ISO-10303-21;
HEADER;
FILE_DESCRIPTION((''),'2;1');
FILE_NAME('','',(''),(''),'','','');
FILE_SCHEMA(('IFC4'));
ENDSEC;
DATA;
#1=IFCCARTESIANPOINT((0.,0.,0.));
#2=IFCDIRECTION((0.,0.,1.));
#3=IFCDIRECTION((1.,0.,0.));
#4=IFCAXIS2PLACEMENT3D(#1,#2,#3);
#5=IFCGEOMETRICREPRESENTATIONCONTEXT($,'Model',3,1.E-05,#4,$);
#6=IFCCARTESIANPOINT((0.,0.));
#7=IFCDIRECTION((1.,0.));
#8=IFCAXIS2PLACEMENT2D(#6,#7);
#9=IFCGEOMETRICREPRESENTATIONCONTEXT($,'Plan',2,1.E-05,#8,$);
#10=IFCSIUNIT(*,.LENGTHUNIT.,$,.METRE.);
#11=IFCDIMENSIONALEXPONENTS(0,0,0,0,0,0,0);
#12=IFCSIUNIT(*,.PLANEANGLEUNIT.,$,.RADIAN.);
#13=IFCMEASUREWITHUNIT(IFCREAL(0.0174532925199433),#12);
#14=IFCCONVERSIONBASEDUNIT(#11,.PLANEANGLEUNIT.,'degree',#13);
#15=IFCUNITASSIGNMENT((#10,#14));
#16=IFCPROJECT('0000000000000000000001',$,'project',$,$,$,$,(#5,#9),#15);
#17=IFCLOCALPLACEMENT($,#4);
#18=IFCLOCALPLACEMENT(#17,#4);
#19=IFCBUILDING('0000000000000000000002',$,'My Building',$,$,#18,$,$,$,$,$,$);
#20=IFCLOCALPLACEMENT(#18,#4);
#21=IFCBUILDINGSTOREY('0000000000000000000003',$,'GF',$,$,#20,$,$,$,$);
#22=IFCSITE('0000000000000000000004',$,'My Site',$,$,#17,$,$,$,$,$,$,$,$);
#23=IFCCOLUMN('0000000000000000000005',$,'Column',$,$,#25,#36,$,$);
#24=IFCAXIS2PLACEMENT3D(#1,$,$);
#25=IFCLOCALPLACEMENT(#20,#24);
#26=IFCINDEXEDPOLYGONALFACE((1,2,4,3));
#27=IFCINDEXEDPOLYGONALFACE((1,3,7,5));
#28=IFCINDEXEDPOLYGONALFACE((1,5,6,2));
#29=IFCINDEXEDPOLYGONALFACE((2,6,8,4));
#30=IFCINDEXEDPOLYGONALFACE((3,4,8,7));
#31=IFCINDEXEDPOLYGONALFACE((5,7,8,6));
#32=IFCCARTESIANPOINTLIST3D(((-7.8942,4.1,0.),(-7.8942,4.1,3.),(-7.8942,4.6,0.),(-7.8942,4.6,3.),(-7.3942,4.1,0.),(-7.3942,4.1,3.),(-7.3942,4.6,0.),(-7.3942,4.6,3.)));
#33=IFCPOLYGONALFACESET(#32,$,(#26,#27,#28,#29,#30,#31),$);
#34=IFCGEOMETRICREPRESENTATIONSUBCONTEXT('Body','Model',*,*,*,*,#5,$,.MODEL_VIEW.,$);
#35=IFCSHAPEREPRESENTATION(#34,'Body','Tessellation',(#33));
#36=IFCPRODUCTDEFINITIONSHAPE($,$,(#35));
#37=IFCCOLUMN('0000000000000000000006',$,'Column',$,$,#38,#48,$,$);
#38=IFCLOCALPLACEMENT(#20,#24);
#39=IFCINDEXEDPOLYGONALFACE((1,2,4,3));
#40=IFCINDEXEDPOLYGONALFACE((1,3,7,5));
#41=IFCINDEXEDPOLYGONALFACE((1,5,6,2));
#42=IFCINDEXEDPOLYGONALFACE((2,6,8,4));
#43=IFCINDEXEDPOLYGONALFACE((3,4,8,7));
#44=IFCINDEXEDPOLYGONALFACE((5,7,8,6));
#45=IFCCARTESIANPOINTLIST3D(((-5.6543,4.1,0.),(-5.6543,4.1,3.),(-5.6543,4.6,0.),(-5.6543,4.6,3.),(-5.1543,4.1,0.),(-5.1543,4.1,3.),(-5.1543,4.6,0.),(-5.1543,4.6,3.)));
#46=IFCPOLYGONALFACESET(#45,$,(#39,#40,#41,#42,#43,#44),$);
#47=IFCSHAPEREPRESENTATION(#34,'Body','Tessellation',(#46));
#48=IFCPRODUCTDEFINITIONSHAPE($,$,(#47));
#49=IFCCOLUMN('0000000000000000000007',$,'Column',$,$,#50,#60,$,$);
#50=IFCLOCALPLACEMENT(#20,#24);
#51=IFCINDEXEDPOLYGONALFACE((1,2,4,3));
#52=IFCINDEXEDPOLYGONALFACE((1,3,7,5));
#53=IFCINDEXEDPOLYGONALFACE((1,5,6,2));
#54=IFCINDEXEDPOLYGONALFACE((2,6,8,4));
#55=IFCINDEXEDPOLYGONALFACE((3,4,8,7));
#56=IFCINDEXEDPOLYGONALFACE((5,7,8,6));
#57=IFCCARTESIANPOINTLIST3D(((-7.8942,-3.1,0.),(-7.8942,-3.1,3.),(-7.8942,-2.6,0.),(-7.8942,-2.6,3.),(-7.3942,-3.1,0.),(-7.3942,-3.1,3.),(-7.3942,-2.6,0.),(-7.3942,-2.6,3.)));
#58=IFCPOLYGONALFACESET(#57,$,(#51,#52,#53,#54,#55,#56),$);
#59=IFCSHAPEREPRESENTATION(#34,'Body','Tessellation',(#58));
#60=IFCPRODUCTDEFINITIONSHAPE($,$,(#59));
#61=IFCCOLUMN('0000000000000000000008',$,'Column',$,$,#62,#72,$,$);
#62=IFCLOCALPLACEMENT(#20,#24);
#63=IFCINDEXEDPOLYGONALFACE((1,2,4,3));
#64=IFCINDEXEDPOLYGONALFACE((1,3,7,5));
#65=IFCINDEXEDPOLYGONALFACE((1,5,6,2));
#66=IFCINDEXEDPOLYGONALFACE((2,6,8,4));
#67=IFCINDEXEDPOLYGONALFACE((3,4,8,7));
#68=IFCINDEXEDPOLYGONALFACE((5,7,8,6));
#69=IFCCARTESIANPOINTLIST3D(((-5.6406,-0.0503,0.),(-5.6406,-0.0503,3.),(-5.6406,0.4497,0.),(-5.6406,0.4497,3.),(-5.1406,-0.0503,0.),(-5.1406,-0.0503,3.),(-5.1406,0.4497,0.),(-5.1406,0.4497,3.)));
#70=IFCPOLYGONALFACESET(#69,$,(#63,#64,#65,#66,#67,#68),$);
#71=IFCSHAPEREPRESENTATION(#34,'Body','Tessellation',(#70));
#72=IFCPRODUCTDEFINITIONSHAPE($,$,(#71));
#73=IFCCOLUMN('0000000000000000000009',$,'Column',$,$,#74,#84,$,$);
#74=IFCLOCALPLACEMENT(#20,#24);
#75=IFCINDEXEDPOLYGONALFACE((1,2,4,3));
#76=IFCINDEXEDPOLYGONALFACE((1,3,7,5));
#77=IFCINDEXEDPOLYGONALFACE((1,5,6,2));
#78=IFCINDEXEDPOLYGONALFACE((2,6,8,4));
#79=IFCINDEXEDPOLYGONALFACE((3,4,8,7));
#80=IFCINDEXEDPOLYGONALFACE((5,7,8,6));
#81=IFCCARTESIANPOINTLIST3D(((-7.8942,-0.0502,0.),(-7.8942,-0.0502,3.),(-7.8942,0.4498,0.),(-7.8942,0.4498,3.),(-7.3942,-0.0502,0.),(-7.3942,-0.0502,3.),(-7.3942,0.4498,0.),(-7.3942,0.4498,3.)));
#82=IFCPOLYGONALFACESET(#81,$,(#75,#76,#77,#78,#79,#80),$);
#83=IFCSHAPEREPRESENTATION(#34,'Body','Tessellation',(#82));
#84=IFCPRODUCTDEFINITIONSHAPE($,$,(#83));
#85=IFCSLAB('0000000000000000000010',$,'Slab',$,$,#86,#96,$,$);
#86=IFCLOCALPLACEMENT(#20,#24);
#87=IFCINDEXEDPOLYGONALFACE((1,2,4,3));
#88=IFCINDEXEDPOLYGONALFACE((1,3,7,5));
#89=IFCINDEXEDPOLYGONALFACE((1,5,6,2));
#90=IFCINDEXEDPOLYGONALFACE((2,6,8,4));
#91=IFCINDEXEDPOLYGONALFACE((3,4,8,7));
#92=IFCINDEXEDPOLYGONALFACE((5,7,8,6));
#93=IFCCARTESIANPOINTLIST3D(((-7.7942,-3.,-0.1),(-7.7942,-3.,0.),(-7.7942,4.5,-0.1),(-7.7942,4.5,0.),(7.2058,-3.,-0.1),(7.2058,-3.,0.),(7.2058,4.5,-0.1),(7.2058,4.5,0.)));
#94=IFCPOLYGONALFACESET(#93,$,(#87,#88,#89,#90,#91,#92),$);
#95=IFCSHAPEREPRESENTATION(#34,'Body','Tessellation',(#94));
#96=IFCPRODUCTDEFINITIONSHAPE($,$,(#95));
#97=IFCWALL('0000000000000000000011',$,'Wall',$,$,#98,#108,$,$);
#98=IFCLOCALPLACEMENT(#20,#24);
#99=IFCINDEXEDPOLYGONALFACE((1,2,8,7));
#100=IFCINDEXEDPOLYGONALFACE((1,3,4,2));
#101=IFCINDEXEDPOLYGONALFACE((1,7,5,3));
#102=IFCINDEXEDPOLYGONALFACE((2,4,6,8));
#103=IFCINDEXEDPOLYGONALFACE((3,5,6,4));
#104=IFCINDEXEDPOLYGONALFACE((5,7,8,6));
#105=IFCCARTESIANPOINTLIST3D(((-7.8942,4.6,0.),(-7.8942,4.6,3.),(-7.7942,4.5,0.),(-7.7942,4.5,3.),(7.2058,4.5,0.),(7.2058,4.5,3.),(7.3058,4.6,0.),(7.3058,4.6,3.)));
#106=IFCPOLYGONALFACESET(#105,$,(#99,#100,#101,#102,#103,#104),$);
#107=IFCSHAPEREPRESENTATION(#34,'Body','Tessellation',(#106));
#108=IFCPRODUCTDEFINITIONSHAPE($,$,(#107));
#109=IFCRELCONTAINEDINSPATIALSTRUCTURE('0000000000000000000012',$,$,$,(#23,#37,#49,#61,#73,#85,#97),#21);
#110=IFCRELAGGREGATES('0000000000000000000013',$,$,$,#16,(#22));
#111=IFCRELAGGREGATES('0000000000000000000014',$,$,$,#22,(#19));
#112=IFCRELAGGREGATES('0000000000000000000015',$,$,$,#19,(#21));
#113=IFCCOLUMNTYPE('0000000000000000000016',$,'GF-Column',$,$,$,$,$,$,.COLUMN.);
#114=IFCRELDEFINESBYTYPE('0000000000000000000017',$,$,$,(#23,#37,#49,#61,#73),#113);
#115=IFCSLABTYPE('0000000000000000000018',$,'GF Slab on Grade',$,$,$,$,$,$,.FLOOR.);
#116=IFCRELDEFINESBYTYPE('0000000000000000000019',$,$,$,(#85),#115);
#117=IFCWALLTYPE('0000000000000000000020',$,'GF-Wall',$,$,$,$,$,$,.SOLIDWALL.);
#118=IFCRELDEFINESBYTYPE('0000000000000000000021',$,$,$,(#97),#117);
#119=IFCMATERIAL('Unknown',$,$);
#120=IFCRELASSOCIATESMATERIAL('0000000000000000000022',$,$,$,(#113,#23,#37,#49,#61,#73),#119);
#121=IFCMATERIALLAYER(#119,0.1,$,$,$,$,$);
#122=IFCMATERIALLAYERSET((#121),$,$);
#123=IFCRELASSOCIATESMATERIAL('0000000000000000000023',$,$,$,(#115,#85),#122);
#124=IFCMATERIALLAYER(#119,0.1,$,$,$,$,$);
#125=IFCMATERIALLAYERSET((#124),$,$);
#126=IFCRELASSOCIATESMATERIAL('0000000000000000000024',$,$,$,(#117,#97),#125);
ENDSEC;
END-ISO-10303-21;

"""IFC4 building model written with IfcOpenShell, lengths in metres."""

from ifc_helpers import new_model, entity, si_unit, converted_unit, frame, origin_with_axes, origin_2d_with_axis, place, context, subcontext, project, spatial, line, indexed_curve, rectangle, outline, extrude, material, layer, layer_set, layer_usage, material_profile, profile_set, profile_usage, type_object, element, save


model = new_model("IFC4")

# Units and contexts
model_context = context("Model", 3, precision=1e-05, world=origin_with_axes())
plan_context = context("Plan", 2, precision=1e-05, world=origin_2d_with_axis())
body_context_1 = subcontext(model_context, "Body", "Model", "MODEL_VIEW")
ifc_project = project(units=[si_unit("LENGTHUNIT", "METRE"), converted_unit("PLANEANGLEUNIT", "degree", entity("IfcReal", 0.0174532925199433), si_unit("PLANEANGLEUNIT", "RADIAN"), dimensions=[0, 0, 0, 0, 0, 0, 0])], contexts=[model_context, plan_context])

# Site, building, storey
site_placement = place(None, origin_with_axes())
site = spatial("IfcSite", under=ifc_project, at=site_placement, Name="My Site")
building_placement = place(site_placement, origin_with_axes())
building = spatial("IfcBuilding", under=site, at=building_placement, Name="My Building")
storey_placement = place(building_placement, origin_with_axes())
storey = spatial("IfcBuildingStorey", under=building, at=storey_placement, Name="GF")

# Columns
ifc_material = material(Name="Unknown")
ifc_material_profile = material_profile(ifc_material, rectangle(XDim=0.5, YDim=0.5))
ifc_profile_set = profile_set([ifc_material_profile])
ifc_profile_usage_1 = profile_usage(ifc_profile_set, cardinal=9)
column_type = type_object("IfcColumnType", Name="GF-Column", PredefinedType="COLUMN", material=ifc_profile_set)
column_1_placement = place(storey_placement, frame((-7.8942, 4.6, 0.0), z_axis=(0.0, 0.0, 1.0), x_axis=(1.0, 0.0, 0.0)))
element("IfcColumn", 1, at=column_1_placement, inside=storey, type_object=column_type, material=ifc_profile_usage_1, Name="Column", context=body_context_1, shape_type="SweptSolid", body=[
    extrude(rectangle(XDim=0.5, YDim=0.5), frame((0.25, -0.25, 0.0), z_axis=(0.0, 0.0, 1.0), x_axis=(1.0, 0.0, 0.0)), (0.0, 0.0, 1.0), 3.0),
])
ifc_profile_usage_2 = profile_usage(ifc_profile_set, cardinal=7)
column_2_placement = place(storey_placement, frame((-5.1543, 4.6, 0.0), z_axis=(0.0, 0.0, 1.0), x_axis=(1.0, 0.0, 0.0)))
element("IfcColumn", 2, at=column_2_placement, inside=storey, type_object=column_type, material=ifc_profile_usage_2, Name="Column", context=body_context_1, shape_type="SweptSolid", body=[
    extrude(rectangle(XDim=0.5, YDim=0.5), frame((-0.25, -0.25, 0.0), z_axis=(0.0, 0.0, 1.0), x_axis=(1.0, 0.0, 0.0)), (0.0, 0.0, 1.0), 3.0),
])
ifc_profile_usage_3 = profile_usage(ifc_profile_set, cardinal=3)
column_3_placement = place(storey_placement, frame((-7.8942, -3.1, 0.0), z_axis=(0.0, 0.0, 1.0), x_axis=(1.0, 0.0, 0.0)))
element("IfcColumn", 3, at=column_3_placement, inside=storey, type_object=column_type, material=ifc_profile_usage_3, Name="Column", context=body_context_1, shape_type="SweptSolid", body=[
    extrude(rectangle(XDim=0.5, YDim=0.5), frame((0.25, 0.25, 0.0), z_axis=(0.0, 0.0, 1.0), x_axis=(1.0, 0.0, 0.0)), (0.0, 0.0, 1.0), 3.0),
])
ifc_profile_usage_4 = profile_usage(ifc_profile_set, cardinal=1)
column_4_placement = place(storey_placement, frame((-5.1406, -0.0503, 0.0), z_axis=(0.0, 0.0, 1.0), x_axis=(1.0, 0.0, 0.0)))
element("IfcColumn", 4, at=column_4_placement, inside=storey, type_object=column_type, material=ifc_profile_usage_4, Name="Column", context=body_context_1, shape_type="SweptSolid", body=[
    extrude(rectangle(XDim=0.5, YDim=0.5), frame((-0.25, 0.25, 0.0), z_axis=(0.0, 0.0, 1.0), x_axis=(1.0, 0.0, 0.0)), (0.0, 0.0, 1.0), 3.0),
])
ifc_profile_usage_5 = profile_usage(ifc_profile_set, cardinal=3)
column_5_placement = place(storey_placement, frame((-7.8942, -0.0502, 0.0), z_axis=(0.0, 0.0, 1.0), x_axis=(1.0, 0.0, 0.0)))
element("IfcColumn", 5, at=column_5_placement, inside=storey, type_object=column_type, material=ifc_profile_usage_5, Name="Column", context=body_context_1, shape_type="SweptSolid", body=[
    extrude(rectangle(XDim=0.5, YDim=0.5), frame((0.25, 0.25, 0.0), z_axis=(0.0, 0.0, 1.0), x_axis=(1.0, 0.0, 0.0)), (0.0, 0.0, 1.0), 3.0),
])

# Slab
ifc_layer_1 = layer(ifc_material, 0.1)
ifc_layer_set_1 = layer_set([ifc_layer_1])
ifc_layer_usage_1 = layer_usage(ifc_layer_set_1, "AXIS3", "POSITIVE", -0.1)
slab_type = type_object("IfcSlabType", Name="GF Slab on Grade", PredefinedType="FLOOR", material=ifc_layer_set_1)
slab_placement = place(storey_placement, frame((-7.7942, 4.5, 0.0), z_axis=(0.0, 0.0, 1.0), x_axis=(1.0, 0.0, 0.0)))
element("IfcSlab", 6, at=slab_placement, inside=storey, type_object=slab_type, material=ifc_layer_usage_1, Name="Slab", context=body_context_1, shape_type="SweptSolid", body=[
    extrude(outline(indexed_curve([(0.0, 0.0), (15.0, 0.0), (15.0, -7.5), (0.0, -7.5), (0.0, 0.0)])), frame((0.0, 0.0, -0.1), z_axis=(0.0, 0.0, 1.0), x_axis=(1.0, 0.0, 0.0)), (0.0, 0.0, 1.0), 0.1),
])

# Wall
ifc_layer_2 = layer(ifc_material, 0.1)
ifc_layer_set_2 = layer_set([ifc_layer_2])
ifc_layer_usage_2 = layer_usage(ifc_layer_set_2, "AXIS2", "POSITIVE", 0.0)
wall_type = type_object("IfcWallType", Name="GF-Wall", PredefinedType="SOLIDWALL", material=ifc_layer_set_2)
wall_1_placement = place(storey_placement, frame((-7.7942, 4.5, 0.0), z_axis=(0.0, 0.0, 1.0), x_axis=(1.0, 0.0, 0.0)))
element("IfcWall", 7, at=wall_1_placement, inside=storey, type_object=wall_type, material=ifc_layer_usage_2, Name="Wall", context=body_context_1, shape_type="SweptSolid", body=[
    extrude(outline(indexed_curve([(0.0, 0.0), (-0.1, 0.1), (15.1, 0.1), (15.0, 0.0)], segments=[line(1, 2, 3, 4, 1)])), origin_with_axes(), (0.0, 0.0, 1.0), 3.0),
])

save(model, "model.ifc")
